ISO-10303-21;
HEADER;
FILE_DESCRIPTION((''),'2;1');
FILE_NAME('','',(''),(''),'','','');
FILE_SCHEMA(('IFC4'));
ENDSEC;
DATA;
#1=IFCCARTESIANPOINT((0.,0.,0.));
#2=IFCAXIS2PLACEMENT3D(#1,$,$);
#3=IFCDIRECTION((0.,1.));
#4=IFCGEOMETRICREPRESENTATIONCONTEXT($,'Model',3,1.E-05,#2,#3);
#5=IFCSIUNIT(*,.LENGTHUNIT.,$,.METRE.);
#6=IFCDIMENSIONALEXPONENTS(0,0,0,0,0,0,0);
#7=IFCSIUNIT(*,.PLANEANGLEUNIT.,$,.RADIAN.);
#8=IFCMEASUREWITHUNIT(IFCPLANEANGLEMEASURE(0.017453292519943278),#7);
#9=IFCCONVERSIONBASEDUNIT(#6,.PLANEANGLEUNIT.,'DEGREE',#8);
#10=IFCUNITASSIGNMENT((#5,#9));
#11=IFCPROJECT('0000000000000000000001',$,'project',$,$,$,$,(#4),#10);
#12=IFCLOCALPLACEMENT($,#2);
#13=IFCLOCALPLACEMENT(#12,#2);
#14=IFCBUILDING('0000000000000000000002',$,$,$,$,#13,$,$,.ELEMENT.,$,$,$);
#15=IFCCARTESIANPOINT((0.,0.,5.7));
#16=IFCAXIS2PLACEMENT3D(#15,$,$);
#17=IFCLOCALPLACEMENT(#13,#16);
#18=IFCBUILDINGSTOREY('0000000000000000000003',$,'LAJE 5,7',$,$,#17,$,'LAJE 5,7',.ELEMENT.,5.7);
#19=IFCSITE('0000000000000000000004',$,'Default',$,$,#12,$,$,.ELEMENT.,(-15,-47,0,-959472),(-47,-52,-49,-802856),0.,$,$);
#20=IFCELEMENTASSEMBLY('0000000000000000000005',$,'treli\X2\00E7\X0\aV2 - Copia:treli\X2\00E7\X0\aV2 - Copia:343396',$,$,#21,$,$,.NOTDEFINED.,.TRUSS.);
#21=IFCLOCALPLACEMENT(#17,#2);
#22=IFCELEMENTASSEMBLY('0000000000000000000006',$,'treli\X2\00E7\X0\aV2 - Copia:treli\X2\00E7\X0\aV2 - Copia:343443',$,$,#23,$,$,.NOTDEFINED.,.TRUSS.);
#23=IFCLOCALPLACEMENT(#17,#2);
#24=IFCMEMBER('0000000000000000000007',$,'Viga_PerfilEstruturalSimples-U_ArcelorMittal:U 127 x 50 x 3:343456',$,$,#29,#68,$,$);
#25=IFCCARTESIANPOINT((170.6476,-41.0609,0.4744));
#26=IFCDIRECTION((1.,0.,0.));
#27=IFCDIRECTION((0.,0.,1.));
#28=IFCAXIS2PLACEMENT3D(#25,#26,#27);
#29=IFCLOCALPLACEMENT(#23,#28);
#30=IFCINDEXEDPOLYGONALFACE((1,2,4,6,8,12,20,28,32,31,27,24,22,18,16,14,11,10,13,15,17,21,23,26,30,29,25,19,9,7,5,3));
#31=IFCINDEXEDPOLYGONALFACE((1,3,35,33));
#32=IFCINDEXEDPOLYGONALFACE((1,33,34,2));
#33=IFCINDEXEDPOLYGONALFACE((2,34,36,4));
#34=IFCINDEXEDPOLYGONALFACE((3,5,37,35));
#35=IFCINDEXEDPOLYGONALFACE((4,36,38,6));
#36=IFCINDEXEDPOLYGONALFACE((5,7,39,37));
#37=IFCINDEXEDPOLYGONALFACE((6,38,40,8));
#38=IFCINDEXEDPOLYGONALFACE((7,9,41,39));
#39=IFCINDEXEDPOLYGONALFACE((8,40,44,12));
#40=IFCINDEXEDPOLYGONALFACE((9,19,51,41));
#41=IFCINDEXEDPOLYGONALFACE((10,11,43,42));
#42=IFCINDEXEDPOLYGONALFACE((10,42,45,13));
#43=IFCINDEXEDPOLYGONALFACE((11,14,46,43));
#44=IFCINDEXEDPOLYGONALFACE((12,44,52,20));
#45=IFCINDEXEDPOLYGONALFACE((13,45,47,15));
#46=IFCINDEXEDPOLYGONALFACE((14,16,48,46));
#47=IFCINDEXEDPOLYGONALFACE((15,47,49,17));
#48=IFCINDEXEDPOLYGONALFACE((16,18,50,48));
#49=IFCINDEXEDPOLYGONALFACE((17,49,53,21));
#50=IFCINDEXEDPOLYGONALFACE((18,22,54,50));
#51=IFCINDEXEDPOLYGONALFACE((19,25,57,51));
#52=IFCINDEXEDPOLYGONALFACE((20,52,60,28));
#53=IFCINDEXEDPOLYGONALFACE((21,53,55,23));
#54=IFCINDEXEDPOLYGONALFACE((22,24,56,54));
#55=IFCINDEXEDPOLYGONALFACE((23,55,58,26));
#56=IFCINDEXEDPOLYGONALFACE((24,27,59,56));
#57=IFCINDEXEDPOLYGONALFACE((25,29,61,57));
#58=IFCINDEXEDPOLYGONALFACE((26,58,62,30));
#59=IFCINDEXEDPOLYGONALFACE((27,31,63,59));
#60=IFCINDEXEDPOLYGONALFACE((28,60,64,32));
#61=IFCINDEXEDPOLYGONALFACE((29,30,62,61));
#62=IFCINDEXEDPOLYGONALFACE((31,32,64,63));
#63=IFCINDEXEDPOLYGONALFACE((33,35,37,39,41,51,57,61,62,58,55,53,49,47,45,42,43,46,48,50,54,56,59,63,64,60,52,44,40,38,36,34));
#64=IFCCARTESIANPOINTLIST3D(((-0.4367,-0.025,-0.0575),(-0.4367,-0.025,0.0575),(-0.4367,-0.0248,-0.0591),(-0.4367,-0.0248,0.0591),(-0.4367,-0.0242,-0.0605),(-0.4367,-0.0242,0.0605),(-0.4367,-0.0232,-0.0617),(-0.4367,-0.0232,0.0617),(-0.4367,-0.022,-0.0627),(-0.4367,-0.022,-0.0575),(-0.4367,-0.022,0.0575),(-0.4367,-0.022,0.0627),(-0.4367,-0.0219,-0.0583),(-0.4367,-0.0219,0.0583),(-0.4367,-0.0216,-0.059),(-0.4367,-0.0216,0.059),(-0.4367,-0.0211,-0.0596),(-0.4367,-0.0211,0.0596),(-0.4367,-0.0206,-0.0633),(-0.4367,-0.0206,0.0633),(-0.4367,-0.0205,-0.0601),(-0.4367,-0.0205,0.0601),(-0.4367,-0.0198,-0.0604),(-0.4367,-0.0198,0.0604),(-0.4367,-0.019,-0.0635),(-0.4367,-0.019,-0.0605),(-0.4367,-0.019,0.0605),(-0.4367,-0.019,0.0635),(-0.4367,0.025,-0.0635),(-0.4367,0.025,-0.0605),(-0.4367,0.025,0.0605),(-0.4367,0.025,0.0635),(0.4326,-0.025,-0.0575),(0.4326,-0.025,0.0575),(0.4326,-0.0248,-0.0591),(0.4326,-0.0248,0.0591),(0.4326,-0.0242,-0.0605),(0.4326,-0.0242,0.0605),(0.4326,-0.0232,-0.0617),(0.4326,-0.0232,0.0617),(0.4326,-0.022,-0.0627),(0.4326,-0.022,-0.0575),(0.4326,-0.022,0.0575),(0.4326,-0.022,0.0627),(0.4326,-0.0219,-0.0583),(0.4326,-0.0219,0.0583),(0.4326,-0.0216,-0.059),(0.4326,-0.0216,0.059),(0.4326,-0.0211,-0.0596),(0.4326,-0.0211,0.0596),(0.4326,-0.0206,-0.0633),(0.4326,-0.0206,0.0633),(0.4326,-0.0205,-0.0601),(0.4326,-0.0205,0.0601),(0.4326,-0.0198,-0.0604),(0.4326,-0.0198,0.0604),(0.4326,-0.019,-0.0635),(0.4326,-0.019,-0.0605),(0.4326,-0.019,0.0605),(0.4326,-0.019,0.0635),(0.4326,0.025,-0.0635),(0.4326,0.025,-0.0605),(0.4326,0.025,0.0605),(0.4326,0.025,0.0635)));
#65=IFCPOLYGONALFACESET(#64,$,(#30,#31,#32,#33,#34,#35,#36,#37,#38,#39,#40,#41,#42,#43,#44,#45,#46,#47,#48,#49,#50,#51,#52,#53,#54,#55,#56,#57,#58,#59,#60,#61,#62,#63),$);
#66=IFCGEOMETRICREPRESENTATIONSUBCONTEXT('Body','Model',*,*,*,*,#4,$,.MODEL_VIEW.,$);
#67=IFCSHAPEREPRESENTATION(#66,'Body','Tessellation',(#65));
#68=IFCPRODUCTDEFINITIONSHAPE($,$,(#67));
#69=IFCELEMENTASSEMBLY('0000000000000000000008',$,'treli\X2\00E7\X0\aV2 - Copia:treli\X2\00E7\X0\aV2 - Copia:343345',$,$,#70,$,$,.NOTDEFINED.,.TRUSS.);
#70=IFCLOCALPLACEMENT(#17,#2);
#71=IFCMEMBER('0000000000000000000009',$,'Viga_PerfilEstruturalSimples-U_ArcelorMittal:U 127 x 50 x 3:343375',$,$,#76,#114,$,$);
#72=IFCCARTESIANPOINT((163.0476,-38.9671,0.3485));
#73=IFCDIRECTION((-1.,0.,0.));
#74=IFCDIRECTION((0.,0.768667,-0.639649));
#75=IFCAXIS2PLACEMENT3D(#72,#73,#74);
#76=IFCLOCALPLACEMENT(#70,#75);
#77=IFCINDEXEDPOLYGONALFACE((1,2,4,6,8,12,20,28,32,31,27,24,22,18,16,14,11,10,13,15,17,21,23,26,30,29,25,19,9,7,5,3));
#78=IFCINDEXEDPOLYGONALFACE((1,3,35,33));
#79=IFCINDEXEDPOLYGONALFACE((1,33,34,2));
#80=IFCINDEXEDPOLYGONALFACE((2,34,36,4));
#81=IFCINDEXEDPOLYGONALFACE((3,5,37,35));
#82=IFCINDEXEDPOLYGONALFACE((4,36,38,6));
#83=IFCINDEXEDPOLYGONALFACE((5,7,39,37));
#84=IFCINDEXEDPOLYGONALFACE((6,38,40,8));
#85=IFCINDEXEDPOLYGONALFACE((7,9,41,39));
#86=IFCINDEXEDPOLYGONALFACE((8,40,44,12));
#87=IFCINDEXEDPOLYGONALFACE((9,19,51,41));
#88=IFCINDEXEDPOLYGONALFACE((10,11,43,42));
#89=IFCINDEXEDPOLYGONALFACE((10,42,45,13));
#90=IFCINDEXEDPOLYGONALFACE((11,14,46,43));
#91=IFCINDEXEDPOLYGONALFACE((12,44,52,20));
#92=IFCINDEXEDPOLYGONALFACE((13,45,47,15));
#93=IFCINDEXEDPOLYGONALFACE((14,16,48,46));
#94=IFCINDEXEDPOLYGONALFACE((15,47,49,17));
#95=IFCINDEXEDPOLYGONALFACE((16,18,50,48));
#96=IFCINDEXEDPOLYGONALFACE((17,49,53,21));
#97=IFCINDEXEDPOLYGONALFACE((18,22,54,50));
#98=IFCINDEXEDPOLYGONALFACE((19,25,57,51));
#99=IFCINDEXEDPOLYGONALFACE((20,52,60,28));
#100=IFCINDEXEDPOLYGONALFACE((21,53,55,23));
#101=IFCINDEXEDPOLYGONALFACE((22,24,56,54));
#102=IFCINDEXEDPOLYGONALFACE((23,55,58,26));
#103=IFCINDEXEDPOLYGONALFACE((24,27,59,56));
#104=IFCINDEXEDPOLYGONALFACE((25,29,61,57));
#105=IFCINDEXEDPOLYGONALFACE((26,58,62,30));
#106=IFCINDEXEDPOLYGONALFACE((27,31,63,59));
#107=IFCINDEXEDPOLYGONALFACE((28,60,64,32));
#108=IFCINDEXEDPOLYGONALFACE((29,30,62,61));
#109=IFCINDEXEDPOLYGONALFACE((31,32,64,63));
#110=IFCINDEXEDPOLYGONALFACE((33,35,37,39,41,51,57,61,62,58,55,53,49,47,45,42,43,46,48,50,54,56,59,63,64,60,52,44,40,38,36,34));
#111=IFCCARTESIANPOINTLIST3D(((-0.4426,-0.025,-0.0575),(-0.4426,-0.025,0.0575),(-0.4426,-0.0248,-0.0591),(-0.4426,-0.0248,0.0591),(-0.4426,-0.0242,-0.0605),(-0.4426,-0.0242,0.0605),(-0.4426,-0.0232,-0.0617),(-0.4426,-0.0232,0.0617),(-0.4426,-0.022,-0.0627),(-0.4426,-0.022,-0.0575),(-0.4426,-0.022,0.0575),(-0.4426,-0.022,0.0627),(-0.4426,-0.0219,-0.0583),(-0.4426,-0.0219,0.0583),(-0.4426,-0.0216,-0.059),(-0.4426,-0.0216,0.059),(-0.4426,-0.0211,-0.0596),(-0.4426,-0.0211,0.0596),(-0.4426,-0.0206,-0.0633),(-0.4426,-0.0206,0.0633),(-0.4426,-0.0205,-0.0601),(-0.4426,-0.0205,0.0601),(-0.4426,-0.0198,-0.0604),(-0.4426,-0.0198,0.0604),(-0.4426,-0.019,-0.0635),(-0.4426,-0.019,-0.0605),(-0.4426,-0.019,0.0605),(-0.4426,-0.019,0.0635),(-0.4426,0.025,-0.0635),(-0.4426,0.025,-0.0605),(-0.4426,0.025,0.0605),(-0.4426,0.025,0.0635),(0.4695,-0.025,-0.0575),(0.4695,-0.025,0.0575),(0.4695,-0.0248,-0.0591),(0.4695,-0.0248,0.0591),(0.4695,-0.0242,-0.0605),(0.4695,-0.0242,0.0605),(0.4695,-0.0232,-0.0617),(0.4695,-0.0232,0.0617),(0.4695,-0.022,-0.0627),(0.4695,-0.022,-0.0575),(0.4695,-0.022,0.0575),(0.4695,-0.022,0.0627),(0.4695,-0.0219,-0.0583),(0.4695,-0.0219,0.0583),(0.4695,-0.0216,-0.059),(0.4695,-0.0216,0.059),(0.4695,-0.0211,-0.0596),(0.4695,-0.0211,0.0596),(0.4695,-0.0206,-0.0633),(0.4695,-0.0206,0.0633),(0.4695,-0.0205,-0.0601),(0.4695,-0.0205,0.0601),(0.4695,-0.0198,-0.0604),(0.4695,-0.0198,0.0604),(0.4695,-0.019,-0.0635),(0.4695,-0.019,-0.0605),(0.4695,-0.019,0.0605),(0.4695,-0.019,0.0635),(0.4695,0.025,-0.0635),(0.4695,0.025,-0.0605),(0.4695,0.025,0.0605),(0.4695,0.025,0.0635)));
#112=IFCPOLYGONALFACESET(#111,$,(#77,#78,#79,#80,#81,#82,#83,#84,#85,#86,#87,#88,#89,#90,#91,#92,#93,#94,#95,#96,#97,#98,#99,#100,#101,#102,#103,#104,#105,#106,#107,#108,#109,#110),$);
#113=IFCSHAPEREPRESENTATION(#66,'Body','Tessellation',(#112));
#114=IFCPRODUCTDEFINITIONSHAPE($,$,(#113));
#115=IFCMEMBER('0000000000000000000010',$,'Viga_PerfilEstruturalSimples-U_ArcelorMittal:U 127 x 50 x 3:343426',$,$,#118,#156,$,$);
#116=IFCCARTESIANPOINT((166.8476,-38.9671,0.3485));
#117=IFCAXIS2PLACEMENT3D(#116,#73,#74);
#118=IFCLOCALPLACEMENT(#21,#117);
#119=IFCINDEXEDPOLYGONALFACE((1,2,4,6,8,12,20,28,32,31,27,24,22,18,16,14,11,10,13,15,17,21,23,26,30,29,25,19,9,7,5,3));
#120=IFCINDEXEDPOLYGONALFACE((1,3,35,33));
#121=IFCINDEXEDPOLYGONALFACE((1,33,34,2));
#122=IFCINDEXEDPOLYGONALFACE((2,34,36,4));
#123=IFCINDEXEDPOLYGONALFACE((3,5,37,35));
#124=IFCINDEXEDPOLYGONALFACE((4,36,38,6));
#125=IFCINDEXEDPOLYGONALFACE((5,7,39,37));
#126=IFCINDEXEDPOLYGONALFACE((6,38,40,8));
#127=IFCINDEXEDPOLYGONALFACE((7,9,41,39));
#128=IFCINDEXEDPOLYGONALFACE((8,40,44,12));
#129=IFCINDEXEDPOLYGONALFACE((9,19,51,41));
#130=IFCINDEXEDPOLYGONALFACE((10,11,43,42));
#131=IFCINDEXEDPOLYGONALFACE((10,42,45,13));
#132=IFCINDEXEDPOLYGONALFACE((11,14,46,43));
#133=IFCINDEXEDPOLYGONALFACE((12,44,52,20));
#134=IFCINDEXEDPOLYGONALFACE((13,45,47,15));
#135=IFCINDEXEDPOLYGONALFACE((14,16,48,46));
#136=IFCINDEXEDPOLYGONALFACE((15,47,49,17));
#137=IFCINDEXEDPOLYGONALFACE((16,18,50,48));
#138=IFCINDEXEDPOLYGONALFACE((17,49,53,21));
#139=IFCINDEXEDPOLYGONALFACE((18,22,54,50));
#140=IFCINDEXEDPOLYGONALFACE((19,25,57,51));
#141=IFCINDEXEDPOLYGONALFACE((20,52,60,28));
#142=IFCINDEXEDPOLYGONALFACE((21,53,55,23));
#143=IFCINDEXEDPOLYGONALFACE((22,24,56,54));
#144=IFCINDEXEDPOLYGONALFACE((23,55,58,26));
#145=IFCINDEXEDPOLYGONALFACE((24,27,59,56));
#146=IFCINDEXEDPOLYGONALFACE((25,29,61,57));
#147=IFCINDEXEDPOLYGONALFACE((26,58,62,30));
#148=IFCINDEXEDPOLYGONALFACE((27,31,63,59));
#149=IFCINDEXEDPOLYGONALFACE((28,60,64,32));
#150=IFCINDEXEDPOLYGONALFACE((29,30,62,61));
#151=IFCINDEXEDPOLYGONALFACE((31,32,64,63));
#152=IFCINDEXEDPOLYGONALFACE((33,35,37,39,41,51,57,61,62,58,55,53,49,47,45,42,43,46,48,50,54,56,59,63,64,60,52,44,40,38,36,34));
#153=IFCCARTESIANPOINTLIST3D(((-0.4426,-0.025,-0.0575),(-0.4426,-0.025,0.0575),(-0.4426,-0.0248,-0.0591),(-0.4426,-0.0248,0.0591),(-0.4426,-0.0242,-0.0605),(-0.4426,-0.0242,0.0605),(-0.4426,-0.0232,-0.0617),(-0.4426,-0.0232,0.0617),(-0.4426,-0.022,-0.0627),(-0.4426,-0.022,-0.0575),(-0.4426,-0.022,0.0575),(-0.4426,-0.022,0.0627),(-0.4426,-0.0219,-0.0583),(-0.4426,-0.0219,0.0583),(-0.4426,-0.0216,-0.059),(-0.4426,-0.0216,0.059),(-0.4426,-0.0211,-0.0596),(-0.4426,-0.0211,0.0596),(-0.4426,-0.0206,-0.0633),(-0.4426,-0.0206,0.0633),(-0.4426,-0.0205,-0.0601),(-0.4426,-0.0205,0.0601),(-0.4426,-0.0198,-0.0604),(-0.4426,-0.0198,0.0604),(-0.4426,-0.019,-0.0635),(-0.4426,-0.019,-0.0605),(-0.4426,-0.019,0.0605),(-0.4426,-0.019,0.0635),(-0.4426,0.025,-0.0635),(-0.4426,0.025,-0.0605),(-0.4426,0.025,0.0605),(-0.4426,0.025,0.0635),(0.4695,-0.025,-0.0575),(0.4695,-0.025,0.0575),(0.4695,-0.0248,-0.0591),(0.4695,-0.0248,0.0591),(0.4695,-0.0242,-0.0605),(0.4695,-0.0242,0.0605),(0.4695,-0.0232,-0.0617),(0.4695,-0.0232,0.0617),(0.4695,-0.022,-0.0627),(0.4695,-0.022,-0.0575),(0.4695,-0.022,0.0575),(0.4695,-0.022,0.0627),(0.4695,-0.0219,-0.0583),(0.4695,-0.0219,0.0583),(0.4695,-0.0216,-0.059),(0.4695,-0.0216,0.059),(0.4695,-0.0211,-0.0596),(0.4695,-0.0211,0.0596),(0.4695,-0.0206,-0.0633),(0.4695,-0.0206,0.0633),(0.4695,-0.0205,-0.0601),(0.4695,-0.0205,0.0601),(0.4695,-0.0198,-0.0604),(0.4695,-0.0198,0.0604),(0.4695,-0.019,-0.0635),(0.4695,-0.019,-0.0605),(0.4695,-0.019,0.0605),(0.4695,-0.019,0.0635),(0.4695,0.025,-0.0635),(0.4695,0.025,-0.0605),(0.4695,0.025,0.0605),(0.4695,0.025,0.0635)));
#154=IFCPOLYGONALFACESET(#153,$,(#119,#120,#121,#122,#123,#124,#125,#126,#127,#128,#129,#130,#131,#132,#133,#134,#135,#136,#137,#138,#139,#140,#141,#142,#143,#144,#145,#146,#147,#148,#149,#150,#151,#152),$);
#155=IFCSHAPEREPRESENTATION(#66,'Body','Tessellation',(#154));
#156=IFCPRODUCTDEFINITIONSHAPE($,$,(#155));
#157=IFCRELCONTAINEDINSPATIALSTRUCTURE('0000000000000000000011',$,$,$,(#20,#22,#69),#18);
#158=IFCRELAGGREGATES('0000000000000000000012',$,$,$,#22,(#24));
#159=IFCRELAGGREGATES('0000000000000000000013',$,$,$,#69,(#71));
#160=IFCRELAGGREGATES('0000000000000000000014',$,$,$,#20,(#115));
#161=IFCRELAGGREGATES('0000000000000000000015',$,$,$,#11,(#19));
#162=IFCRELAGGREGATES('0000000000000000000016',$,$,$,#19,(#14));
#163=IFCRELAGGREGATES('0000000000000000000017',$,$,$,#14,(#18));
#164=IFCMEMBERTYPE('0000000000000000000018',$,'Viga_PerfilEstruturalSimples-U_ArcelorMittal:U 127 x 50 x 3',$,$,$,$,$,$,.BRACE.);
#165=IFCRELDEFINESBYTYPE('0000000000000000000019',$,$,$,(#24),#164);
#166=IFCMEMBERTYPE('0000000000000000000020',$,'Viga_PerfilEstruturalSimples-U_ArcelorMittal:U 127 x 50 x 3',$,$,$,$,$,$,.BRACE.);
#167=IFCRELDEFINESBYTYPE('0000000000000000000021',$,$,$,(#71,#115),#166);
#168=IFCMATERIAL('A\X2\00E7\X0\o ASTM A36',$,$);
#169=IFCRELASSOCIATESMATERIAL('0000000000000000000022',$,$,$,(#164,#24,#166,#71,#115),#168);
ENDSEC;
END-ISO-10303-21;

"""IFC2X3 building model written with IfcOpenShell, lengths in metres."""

from ifc_helpers import new_model, entity, si_unit, converted_unit, direction, frame, frame_2d, origin, place, context, subcontext, project, spatial, polyline, circle_curve, parameter, trimmed, segment, composite_curve, outline, extrude, source, transform, mapped, material, type_object, type_shapes, element, aggregate, save


model = new_model("IFC2X3")

# Units and contexts
model_context = context("Model", 3, precision=1e-05, world=origin(), true_north=direction((0.0, 1.0)))
body_context = subcontext(model_context, "Body", "Model", "MODEL_VIEW")
ifc_project = project(units=[si_unit("LENGTHUNIT", "METRE"), converted_unit("PLANEANGLEUNIT", "DEGREE", entity("IfcPlaneAngleMeasure", 0.017453292519943278), si_unit("PLANEANGLEUNIT", "RADIAN"), dimensions=[0, 0, 0, 0, 0, 0, 0])], contexts=[model_context])

# Site, building, storey
site_placement = place(None, origin())
site = spatial("IfcSite", under=ifc_project, at=site_placement, Name="Default", CompositionType="ELEMENT", RefLatitude=(-15, -47, 0, -959472), RefLongitude=(-47, -52, -49, -802856), RefElevation=0.0)
building_placement = place(site_placement, origin())
building = spatial("IfcBuilding", under=site, at=building_placement, CompositionType="ELEMENT")
storey_placement = place(building_placement, frame((0.0, 0.0, 5.7)))
storey = spatial("IfcBuildingStorey", under=building, at=storey_placement, Name="LAJE 5,7", LongName="LAJE 5,7", CompositionType="ELEMENT", Elevation=5.7)

# Element assemblies
assembly_1_placement = place(storey_placement, origin())
assembly_1 = element("IfcElementAssembly", 1, at=assembly_1_placement, inside=storey, Name="treliçaV2 - Copia:treliçaV2 - Copia:343396", AssemblyPlace="NOTDEFINED", PredefinedType="TRUSS")
ifc_material = material(Name="Aço ASTM A36")
assembly_2_placement = place(storey_placement, origin())
assembly_2 = element("IfcElementAssembly", 2, at=assembly_2_placement, inside=storey, Name="treliçaV2 - Copia:treliçaV2 - Copia:343443", AssemblyPlace="NOTDEFINED", PredefinedType="TRUSS")

# Member
member_type_1 = type_object("IfcMemberType", Name="Viga_PerfilEstruturalSimples-U_ArcelorMittal:U 127 x 50 x 3", PredefinedType="BRACE", material=ifc_material)
shared_shape_1 = source(origin(), body_context, "Body", "SweptSolid", [
    extrude(outline(composite_curve([segment(polyline([(-0.0575, -0.0192), (0.0575, -0.0192)]), True, "CONTINUOUS"), segment(trimmed(circle_curve(frame_2d((0.0575, -0.0132), x_axis=(0.0, 1.0)), 0.006), [parameter(180.0)], [parameter(270.0)], True, "PARAMETER"), True, "CONTINUOUS"), segment(polyline([(0.0635, -0.0132), (0.0635, 0.0308)]), True, "CONTINUOUS"), segment(polyline([(0.0635, 0.0308), (0.0605, 0.0308)]), True, "CONTINUOUS"), segment(polyline([(0.0605, 0.0308), (0.0605, -0.0132)]), True, "CONTINUOUS"), segment(trimmed(circle_curve(frame_2d((0.0575, -0.0132), x_axis=(0.0, 1.0)), 0.003), [parameter(180.0)], [parameter(270.0)], True, "PARAMETER"), False, "CONTINUOUS"), segment(polyline([(0.0575, -0.0162), (-0.0575, -0.0162)]), True, "CONTINUOUS"), segment(trimmed(circle_curve(frame_2d((-0.0575, -0.0132), x_axis=(0.0, 1.0)), 0.003), [parameter(90.0)], [parameter(180.0)], True, "PARAMETER"), False, "CONTINUOUS"), segment(polyline([(-0.0605, -0.0132), (-0.0605, 0.0308)]), True, "CONTINUOUS"), segment(polyline([(-0.0605, 0.0308), (-0.0635, 0.0308)]), True, "CONTINUOUS"), segment(polyline([(-0.0635, 0.0308), (-0.0635, -0.0132)]), True, "CONTINUOUS"), segment(trimmed(circle_curve(frame_2d((-0.0575, -0.0132), x_axis=(0.0, 1.0)), 0.006), [parameter(90.0)], [parameter(180.0)], True, "PARAMETER"), True, "CONTINUOUS")], self_intersect=False)), frame((-0.4367, -0.0058, 0.0), z_axis=(1.0, 0.0, 0.0), x_axis=(0.0, 0.0, -1.0)), (0.0, 0.0, 1.0), 0.8693),
])
type_shapes(member_type_1, [shared_shape_1])
member_1_placement = place(assembly_2_placement, frame((170.6476, -41.0609, 0.4744), z_axis=(1.0, 0.0, 0.0), x_axis=(0.0, 0.0, 1.0)))
member_1 = element("IfcMember", 3, at=member_1_placement, type_object=member_type_1, material=ifc_material, Name="Viga_PerfilEstruturalSimples-U_ArcelorMittal:U 127 x 50 x 3:343456", context=body_context, shape_type="MappedRepresentation", body=[
    mapped(shared_shape_1, transform((0.0, 0.0, 0.0), scale=1.0)),
])
aggregate(assembly_2, [member_1])

# Element assembly
assembly_3_placement = place(storey_placement, origin())
assembly_3 = element("IfcElementAssembly", 4, at=assembly_3_placement, inside=storey, Name="treliçaV2 - Copia:treliçaV2 - Copia:343345", AssemblyPlace="NOTDEFINED", PredefinedType="TRUSS")

# Members
member_type_2 = type_object("IfcMemberType", Name="Viga_PerfilEstruturalSimples-U_ArcelorMittal:U 127 x 50 x 3", PredefinedType="BRACE", material=ifc_material)
shared_shape_2 = source(origin(), body_context, "Body", "SweptSolid", [
    extrude(outline(composite_curve([segment(polyline([(-0.0575, -0.0192), (0.0575, -0.0192)]), True, "CONTINUOUS"), segment(trimmed(circle_curve(frame_2d((0.0575, -0.0132), x_axis=(0.0, 1.0)), 0.006), [parameter(180.0)], [parameter(270.0)], True, "PARAMETER"), True, "CONTINUOUS"), segment(polyline([(0.0635, -0.0132), (0.0635, 0.0308)]), True, "CONTINUOUS"), segment(polyline([(0.0635, 0.0308), (0.0605, 0.0308)]), True, "CONTINUOUS"), segment(polyline([(0.0605, 0.0308), (0.0605, -0.0132)]), True, "CONTINUOUS"), segment(trimmed(circle_curve(frame_2d((0.0575, -0.0132), x_axis=(0.0, 1.0)), 0.003), [parameter(180.0)], [parameter(270.0)], True, "PARAMETER"), False, "CONTINUOUS"), segment(polyline([(0.0575, -0.0162), (-0.0575, -0.0162)]), True, "CONTINUOUS"), segment(trimmed(circle_curve(frame_2d((-0.0575, -0.0132), x_axis=(0.0, 1.0)), 0.003), [parameter(90.0)], [parameter(180.0)], True, "PARAMETER"), False, "CONTINUOUS"), segment(polyline([(-0.0605, -0.0132), (-0.0605, 0.0308)]), True, "CONTINUOUS"), segment(polyline([(-0.0605, 0.0308), (-0.0635, 0.0308)]), True, "CONTINUOUS"), segment(polyline([(-0.0635, 0.0308), (-0.0635, -0.0132)]), True, "CONTINUOUS"), segment(trimmed(circle_curve(frame_2d((-0.0575, -0.0132), x_axis=(0.0, 1.0)), 0.006), [parameter(90.0)], [parameter(180.0)], True, "PARAMETER"), True, "CONTINUOUS")], self_intersect=False)), frame((-0.4426, -0.0058, 0.0), z_axis=(1.0, 0.0, 0.0), x_axis=(0.0, 0.0, -1.0)), (0.0, 0.0, 1.0), 0.9121),
])
type_shapes(member_type_2, [shared_shape_2])
member_2_placement = place(assembly_3_placement, frame((163.0476, -38.9671, 0.3485), z_axis=(-1.0, 0.0, 0.0), x_axis=(0.0, 0.768667, -0.639649)))
member_2 = element("IfcMember", 5, at=member_2_placement, type_object=member_type_2, material=ifc_material, Name="Viga_PerfilEstruturalSimples-U_ArcelorMittal:U 127 x 50 x 3:343375", context=body_context, shape_type="MappedRepresentation", body=[
    mapped(shared_shape_2, transform((0.0, 0.0, 0.0), scale=1.0)),
])
member_3_placement = place(assembly_1_placement, frame((166.8476, -38.9671, 0.3485), z_axis=(-1.0, 0.0, 0.0), x_axis=(0.0, 0.768667, -0.639649)))
member_3 = element("IfcMember", 6, at=member_3_placement, type_object=member_type_2, material=ifc_material, Name="Viga_PerfilEstruturalSimples-U_ArcelorMittal:U 127 x 50 x 3:343426", context=body_context, shape_type="MappedRepresentation", body=[
    mapped(shared_shape_2, transform((0.0, 0.0, 0.0), scale=1.0)),
])
aggregate(assembly_3, [member_2])
aggregate(assembly_1, [member_3])

save(model, "model.ifc")
